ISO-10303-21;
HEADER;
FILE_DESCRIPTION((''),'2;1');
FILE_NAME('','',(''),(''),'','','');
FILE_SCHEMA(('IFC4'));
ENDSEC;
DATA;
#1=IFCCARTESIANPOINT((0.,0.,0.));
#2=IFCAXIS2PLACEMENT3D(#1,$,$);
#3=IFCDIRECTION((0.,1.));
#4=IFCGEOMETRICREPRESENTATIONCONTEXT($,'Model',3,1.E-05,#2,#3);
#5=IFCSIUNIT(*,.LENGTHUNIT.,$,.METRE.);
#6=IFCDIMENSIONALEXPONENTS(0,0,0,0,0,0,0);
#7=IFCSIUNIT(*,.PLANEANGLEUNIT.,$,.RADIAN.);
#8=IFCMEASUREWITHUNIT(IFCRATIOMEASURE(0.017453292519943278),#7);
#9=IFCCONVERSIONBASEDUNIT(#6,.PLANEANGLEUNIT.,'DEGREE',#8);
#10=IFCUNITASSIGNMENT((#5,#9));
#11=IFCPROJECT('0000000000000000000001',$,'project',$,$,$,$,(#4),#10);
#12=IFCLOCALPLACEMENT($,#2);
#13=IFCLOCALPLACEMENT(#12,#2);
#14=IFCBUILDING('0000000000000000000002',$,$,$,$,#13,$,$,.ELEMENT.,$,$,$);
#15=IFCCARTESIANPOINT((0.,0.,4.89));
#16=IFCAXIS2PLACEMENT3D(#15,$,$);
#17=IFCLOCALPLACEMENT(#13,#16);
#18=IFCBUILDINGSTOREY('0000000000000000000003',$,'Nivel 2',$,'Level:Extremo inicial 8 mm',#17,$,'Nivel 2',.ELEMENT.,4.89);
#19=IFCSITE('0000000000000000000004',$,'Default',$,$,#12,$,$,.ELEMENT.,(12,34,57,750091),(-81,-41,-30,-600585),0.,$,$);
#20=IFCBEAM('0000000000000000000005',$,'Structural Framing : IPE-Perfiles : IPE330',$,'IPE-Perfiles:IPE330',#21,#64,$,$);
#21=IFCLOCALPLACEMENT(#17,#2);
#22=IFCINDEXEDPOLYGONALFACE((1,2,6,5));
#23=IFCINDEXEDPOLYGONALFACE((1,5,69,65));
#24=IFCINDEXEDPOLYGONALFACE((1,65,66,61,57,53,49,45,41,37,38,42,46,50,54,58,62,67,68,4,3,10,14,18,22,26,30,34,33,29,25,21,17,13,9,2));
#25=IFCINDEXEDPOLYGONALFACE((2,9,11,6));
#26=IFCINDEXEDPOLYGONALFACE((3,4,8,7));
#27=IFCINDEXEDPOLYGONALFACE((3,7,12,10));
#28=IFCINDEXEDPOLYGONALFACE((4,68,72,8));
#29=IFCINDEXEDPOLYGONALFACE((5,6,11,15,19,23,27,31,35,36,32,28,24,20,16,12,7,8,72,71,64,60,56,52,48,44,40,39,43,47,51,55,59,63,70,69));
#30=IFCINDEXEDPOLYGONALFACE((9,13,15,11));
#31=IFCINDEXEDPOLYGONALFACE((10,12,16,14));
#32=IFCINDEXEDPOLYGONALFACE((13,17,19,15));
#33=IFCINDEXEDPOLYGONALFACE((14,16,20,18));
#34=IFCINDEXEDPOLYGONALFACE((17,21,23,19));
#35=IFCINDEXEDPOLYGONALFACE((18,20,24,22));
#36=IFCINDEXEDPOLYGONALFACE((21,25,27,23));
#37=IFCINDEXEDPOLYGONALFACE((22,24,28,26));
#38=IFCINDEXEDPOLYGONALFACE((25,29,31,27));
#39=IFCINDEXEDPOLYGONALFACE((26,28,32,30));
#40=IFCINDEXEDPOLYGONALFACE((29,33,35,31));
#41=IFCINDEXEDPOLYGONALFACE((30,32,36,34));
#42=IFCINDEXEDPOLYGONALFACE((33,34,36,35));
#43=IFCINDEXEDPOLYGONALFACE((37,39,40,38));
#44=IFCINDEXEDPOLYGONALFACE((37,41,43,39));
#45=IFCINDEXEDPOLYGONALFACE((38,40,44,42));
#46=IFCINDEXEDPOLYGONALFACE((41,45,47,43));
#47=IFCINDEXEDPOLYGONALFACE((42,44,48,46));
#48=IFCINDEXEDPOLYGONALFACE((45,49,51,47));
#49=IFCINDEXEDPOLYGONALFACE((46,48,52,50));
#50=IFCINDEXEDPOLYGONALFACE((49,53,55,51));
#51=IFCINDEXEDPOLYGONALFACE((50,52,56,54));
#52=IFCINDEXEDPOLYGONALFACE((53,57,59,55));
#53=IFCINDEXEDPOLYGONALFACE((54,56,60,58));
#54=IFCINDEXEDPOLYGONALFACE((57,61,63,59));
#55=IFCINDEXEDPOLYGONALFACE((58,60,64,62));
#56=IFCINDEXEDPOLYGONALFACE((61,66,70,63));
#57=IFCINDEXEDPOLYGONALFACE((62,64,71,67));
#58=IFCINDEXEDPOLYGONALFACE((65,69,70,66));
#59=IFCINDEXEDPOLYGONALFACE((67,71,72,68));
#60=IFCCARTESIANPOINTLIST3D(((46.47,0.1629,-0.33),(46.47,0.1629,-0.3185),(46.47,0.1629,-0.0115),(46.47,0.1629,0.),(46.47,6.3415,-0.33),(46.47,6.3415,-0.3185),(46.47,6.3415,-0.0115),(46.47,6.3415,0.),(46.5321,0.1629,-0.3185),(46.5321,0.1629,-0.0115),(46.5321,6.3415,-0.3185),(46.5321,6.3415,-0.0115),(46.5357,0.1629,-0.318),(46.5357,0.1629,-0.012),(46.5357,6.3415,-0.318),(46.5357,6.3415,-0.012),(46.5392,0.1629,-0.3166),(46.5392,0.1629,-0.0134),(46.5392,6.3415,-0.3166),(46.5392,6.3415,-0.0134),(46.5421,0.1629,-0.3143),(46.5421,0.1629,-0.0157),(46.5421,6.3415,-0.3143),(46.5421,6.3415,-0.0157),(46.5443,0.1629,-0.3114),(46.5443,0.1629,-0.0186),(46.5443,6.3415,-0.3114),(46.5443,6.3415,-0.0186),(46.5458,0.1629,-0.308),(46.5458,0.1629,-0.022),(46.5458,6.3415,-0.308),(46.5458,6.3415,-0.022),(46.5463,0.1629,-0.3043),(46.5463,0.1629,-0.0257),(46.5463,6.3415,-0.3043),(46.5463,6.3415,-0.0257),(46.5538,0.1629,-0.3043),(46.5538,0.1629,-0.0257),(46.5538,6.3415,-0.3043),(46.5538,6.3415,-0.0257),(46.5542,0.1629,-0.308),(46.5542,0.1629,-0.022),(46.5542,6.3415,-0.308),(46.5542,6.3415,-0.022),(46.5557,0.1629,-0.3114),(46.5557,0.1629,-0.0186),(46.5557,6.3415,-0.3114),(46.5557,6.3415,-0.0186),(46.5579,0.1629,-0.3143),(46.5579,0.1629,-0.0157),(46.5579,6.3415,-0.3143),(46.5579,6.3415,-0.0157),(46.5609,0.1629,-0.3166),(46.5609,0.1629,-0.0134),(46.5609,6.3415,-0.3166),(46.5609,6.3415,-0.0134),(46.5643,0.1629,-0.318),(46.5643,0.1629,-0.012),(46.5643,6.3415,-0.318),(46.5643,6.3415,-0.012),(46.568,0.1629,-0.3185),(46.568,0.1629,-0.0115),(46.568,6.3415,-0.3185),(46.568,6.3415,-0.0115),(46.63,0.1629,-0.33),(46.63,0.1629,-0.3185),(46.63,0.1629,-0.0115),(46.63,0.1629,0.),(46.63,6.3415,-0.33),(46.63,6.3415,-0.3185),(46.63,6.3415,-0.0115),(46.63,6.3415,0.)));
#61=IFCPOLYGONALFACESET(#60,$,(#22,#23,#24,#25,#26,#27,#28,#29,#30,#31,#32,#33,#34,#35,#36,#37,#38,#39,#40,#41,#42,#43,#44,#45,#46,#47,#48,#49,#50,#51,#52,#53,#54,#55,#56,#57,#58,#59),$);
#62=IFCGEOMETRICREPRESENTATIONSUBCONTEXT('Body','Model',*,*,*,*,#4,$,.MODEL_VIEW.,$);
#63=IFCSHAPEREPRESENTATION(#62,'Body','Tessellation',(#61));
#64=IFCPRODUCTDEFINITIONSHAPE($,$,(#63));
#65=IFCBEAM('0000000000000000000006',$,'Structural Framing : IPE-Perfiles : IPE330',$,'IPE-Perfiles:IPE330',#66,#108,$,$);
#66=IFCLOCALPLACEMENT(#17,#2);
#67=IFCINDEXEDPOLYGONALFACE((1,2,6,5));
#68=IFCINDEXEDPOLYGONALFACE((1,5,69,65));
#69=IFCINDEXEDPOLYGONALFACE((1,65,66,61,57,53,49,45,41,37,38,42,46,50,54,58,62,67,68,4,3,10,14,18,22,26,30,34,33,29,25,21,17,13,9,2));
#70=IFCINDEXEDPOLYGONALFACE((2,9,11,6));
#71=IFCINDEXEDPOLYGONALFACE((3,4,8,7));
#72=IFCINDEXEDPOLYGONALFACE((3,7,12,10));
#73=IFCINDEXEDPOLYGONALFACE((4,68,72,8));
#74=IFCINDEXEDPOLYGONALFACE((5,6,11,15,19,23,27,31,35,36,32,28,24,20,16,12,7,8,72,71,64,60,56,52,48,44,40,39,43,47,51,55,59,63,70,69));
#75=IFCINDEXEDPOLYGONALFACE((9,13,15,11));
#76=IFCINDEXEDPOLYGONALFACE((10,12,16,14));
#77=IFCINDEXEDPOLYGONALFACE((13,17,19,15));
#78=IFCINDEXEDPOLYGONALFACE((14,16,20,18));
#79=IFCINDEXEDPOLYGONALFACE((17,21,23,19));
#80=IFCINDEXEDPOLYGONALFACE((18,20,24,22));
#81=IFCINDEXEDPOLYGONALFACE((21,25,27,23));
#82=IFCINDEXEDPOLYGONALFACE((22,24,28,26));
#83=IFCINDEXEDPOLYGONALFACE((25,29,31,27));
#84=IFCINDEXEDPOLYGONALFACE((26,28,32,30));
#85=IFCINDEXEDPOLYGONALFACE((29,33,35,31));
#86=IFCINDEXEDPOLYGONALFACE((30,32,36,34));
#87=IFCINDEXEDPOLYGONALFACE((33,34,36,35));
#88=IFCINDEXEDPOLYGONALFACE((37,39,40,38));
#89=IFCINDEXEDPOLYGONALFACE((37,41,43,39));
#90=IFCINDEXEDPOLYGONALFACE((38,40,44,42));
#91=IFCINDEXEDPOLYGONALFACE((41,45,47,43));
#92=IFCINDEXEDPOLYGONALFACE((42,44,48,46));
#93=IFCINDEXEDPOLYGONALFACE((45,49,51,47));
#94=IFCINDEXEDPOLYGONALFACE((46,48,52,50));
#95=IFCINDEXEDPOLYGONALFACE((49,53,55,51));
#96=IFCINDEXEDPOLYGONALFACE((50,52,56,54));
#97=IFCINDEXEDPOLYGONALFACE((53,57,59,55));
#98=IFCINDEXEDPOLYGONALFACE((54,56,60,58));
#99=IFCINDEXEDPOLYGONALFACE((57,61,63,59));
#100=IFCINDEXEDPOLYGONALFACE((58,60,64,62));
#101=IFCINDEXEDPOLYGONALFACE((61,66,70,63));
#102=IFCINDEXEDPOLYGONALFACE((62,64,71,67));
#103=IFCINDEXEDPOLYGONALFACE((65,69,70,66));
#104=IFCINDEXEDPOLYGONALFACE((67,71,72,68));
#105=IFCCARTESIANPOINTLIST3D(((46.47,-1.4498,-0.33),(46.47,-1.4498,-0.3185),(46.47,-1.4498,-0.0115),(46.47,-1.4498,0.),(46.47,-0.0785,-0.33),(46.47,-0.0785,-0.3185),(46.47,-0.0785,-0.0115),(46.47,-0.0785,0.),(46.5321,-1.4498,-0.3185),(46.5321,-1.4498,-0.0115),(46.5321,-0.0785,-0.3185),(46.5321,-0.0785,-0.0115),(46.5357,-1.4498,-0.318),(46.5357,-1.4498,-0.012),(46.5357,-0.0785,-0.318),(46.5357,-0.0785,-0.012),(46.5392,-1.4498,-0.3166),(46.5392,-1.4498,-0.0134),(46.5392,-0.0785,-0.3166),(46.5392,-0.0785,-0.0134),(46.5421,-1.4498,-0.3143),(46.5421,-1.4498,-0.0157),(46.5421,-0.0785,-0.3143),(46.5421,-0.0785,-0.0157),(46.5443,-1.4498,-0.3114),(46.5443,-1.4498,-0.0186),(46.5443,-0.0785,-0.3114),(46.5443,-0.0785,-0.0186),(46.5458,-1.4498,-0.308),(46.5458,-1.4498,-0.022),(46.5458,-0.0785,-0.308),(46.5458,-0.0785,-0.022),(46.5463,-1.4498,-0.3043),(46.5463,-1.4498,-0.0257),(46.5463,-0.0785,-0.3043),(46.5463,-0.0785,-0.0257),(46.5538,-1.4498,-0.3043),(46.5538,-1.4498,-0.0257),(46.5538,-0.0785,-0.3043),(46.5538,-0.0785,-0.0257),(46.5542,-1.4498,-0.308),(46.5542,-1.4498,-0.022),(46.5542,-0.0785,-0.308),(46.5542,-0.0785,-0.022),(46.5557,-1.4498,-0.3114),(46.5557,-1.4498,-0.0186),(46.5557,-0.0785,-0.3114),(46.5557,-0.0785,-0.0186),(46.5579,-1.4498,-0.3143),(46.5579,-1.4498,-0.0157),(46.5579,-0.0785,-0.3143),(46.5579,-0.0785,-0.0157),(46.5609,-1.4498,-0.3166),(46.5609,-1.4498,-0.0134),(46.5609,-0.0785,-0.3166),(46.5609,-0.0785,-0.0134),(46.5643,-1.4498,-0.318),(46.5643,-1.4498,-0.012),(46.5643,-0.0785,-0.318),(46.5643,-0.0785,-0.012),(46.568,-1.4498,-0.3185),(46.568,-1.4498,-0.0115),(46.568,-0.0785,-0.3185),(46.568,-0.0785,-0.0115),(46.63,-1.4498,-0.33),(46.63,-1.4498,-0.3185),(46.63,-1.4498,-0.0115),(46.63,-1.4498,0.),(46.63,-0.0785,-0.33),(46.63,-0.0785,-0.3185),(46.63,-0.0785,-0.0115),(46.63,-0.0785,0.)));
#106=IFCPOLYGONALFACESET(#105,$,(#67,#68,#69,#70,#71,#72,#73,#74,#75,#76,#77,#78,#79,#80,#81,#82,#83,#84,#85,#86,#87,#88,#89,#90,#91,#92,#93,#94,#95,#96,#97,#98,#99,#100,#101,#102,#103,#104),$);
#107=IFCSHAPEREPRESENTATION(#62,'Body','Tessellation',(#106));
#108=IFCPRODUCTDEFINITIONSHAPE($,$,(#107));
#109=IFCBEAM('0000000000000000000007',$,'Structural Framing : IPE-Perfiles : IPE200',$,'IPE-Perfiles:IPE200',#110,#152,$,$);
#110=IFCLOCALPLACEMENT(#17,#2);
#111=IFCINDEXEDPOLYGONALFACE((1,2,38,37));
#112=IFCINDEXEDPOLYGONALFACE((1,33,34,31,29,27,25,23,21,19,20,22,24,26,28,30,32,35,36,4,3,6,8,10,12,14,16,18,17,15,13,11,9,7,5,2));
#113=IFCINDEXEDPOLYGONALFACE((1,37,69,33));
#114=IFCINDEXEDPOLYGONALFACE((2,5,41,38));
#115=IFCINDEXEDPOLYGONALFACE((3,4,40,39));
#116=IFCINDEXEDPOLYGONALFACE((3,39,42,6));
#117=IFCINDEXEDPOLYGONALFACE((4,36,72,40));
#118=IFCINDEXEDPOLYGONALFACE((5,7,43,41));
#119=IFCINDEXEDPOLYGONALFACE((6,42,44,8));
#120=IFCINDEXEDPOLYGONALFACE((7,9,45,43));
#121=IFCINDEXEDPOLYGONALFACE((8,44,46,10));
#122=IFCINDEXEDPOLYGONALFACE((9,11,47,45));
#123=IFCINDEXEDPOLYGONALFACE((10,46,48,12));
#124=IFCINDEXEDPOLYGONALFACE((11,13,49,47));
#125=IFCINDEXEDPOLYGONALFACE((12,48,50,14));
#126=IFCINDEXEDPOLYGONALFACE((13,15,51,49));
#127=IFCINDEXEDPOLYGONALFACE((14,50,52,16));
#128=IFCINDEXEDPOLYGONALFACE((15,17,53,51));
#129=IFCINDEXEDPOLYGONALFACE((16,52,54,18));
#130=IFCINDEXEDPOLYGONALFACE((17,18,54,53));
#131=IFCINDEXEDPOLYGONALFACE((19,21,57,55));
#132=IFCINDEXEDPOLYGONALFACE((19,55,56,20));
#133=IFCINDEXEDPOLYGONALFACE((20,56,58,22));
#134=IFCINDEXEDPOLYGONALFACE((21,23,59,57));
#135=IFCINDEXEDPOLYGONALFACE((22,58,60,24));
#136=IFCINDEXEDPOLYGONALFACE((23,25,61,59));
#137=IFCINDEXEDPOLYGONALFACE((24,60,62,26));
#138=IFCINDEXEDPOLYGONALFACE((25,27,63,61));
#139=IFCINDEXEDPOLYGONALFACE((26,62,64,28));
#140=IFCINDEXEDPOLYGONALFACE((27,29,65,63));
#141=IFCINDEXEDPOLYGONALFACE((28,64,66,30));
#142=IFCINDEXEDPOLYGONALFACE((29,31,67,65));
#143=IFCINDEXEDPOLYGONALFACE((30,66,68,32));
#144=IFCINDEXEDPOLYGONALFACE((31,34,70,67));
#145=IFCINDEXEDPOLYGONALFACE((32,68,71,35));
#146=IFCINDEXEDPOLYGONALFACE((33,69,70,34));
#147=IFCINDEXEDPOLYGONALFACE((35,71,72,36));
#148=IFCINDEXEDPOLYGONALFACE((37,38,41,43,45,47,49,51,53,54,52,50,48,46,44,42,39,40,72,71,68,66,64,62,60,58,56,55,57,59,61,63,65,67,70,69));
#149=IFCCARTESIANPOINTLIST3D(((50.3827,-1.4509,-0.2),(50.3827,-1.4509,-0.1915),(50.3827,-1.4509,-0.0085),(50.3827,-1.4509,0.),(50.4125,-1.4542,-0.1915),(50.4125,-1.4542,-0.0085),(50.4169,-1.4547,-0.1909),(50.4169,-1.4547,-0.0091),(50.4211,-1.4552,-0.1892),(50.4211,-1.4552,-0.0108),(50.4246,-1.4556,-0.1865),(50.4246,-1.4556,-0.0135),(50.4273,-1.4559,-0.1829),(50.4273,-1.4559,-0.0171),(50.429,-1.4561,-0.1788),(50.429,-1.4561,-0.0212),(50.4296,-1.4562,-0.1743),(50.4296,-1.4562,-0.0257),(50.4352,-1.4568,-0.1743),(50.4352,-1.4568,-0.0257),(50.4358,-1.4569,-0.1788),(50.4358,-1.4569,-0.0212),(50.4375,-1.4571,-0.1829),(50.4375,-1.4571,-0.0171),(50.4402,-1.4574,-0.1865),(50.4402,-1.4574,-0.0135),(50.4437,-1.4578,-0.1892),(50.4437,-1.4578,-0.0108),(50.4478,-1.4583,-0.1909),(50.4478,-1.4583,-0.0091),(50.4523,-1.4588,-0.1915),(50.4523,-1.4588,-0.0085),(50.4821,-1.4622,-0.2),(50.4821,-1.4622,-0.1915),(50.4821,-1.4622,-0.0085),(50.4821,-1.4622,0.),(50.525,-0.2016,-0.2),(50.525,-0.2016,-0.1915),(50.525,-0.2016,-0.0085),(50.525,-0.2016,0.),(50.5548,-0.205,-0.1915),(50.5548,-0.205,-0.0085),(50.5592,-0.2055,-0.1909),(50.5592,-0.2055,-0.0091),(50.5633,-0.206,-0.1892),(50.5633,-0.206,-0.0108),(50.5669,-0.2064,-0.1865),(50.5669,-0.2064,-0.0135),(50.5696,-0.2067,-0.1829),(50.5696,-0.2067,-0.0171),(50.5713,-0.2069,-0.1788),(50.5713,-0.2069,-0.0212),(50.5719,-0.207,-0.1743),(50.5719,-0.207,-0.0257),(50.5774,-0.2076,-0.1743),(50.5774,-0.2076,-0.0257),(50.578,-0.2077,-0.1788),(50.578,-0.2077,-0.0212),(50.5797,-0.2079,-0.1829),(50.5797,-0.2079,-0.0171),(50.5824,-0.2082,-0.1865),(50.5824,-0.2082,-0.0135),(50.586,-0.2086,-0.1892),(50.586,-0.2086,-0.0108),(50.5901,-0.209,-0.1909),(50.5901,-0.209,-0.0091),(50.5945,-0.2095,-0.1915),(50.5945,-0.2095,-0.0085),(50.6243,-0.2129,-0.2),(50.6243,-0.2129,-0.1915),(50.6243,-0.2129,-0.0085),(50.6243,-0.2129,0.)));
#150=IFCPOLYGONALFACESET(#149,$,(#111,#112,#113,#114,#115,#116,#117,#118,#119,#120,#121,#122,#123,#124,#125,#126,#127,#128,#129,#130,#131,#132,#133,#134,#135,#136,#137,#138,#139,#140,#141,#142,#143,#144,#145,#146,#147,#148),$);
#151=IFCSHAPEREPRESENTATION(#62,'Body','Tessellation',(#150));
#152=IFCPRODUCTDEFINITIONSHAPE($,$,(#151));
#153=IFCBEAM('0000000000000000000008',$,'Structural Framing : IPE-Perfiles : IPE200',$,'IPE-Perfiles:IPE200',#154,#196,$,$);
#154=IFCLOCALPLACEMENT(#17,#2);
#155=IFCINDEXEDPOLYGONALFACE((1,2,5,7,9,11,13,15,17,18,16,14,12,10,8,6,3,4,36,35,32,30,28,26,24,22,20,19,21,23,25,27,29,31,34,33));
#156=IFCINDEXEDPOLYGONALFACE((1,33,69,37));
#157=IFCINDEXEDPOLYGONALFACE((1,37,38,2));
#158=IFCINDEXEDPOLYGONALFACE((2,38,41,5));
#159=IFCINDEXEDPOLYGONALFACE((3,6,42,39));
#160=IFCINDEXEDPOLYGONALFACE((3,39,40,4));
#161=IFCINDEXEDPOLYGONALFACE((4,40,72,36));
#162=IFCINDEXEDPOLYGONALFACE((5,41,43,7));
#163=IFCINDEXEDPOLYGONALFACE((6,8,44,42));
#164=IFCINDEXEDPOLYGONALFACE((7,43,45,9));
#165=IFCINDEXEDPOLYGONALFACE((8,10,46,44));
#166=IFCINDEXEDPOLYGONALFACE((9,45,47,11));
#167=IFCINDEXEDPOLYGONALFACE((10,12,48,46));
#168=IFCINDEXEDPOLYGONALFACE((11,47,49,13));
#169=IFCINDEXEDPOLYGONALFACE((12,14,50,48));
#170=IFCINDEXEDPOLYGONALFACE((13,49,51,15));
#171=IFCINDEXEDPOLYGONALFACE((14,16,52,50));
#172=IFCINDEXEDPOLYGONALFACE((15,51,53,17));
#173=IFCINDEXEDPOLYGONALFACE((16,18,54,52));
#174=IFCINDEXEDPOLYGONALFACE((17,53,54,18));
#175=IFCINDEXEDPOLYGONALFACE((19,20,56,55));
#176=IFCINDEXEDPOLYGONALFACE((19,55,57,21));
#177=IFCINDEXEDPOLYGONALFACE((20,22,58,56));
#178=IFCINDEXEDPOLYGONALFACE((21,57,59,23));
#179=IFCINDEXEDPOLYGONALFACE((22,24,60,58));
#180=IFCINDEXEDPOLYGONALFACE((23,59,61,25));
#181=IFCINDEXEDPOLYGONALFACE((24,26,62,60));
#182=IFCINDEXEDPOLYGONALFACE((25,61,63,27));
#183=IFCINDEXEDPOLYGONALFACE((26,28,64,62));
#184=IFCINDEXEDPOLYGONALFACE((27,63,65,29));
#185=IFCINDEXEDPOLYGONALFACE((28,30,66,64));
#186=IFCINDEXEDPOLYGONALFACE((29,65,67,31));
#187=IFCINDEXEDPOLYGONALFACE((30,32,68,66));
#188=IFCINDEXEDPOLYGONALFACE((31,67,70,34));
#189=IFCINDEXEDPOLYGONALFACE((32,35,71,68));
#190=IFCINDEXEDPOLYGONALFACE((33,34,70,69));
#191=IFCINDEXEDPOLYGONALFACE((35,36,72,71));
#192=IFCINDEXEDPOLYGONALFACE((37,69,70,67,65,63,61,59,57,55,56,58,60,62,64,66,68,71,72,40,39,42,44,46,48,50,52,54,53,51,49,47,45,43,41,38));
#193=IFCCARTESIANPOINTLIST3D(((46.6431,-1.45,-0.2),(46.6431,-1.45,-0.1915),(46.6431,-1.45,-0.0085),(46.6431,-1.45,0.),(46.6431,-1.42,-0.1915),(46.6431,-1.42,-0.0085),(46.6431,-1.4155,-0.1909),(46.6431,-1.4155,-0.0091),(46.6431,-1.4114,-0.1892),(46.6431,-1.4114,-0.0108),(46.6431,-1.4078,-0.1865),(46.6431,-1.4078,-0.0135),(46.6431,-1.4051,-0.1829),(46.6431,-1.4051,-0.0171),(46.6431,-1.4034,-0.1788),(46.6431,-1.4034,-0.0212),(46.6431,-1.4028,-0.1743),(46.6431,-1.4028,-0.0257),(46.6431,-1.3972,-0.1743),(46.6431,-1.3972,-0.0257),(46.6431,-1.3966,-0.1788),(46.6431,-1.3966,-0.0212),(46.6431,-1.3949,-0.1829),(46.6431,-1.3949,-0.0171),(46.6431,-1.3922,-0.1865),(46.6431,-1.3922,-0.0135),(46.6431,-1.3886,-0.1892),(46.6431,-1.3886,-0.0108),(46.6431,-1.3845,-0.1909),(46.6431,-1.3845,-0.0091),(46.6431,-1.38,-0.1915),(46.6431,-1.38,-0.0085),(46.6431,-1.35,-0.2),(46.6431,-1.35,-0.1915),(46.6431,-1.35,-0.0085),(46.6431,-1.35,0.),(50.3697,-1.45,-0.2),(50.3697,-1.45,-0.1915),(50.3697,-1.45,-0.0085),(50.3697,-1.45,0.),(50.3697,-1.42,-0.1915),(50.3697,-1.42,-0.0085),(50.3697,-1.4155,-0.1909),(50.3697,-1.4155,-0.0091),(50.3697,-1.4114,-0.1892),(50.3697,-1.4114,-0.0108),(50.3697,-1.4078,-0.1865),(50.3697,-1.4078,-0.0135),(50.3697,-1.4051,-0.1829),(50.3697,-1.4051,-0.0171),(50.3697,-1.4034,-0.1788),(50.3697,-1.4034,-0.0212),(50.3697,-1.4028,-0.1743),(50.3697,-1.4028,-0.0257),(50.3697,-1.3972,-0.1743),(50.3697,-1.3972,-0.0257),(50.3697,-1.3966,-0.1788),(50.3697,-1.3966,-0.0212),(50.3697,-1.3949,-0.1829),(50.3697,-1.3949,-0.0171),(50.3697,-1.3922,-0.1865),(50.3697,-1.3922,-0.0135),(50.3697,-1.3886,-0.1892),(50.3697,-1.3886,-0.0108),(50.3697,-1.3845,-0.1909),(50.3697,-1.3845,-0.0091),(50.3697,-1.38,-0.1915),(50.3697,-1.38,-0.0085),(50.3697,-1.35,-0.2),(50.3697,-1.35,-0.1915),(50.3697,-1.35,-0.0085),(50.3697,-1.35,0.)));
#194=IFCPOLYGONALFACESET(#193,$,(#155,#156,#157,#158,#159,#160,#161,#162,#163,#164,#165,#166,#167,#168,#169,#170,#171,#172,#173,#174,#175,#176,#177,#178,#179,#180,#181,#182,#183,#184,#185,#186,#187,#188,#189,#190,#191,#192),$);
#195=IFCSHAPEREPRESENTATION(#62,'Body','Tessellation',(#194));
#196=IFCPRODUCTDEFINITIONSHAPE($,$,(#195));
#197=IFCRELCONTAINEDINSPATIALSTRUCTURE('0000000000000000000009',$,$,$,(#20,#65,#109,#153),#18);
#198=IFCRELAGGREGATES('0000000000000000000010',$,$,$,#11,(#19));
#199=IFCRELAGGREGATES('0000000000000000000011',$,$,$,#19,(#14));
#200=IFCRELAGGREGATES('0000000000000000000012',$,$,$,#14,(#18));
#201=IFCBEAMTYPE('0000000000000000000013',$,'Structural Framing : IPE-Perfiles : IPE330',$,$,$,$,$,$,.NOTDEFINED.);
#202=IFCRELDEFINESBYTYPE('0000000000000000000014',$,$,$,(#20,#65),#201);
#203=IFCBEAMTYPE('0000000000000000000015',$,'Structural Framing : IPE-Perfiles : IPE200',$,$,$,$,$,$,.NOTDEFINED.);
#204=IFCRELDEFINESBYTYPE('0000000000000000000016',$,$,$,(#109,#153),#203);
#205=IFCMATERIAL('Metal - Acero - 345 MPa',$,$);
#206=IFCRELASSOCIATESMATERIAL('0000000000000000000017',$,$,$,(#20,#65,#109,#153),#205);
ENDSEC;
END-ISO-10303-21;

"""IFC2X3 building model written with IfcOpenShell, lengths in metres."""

from ifc_helpers import new_model, entity, si_unit, converted_unit, direction, frame, frame_2d, origin, place, context, subcontext, project, spatial, i_section, extrude, material, type_object, element, save


model = new_model("IFC2X3")

# Units and contexts
model_context = context("Model", 3, precision=1e-05, world=origin(), true_north=direction((0.0, 1.0)))
body_context = subcontext(model_context, "Body", "Model", "MODEL_VIEW")
ifc_project = project(units=[si_unit("LENGTHUNIT", "METRE"), converted_unit("PLANEANGLEUNIT", "DEGREE", entity("IfcRatioMeasure", 0.017453292519943278), si_unit("PLANEANGLEUNIT", "RADIAN"), dimensions=[0, 0, 0, 0, 0, 0, 0])], contexts=[model_context])

# Site, building, storey
site_placement = place(None, origin())
site = spatial("IfcSite", under=ifc_project, at=site_placement, Name="Default", CompositionType="ELEMENT", RefLatitude=(12, 34, 57, 750091), RefLongitude=(-81, -41, -30, -600585), RefElevation=0.0)
building_placement = place(site_placement, origin())
building = spatial("IfcBuilding", under=site, at=building_placement, CompositionType="ELEMENT")
storey_placement = place(building_placement, frame((0.0, 0.0, 4.89)))
storey = spatial("IfcBuildingStorey", under=building, at=storey_placement, Name="Nivel 2", ObjectType="Level:Extremo inicial 8 mm", LongName="Nivel 2", CompositionType="ELEMENT", Elevation=4.89)

# Shared definitions
ifc_material_1 = material(Name="Metal - Acero - 345 MPa")

# Beams
beam_type_1 = type_object("IfcBeamType", Name="Structural Framing : IPE-Perfiles : IPE330", PredefinedType="NOTDEFINED")
beam_1_placement = place(storey_placement, frame((46.55, 6.355, 0.0), z_axis=(0.0, 0.0, 1.0), x_axis=(0.0, -1.0, 0.0)))
element("IfcBeam", 1, at=beam_1_placement, inside=storey, type_object=beam_type_1, material=ifc_material_1, Name="Structural Framing : IPE-Perfiles : IPE330", ObjectType="IPE-Perfiles:IPE330", context=body_context, shape_type="SweptSolid", body=[
    extrude(i_section(OverallWidth=0.16, OverallDepth=0.33, WebThickness=0.0075, FlangeThickness=0.0115, FilletRadius=0.0142, at=frame_2d((0.0, 0.0), x_axis=(0.0, 1.0))), frame((0.0134, 0.0, -0.165), z_axis=(1.0, 0.0, 0.0), x_axis=(0.0, 0.0, -1.0)), (0.0, 0.0, 1.0), 6.1786),
])
beam_2_placement = place(storey_placement, frame((46.55, 0.0795, 0.0), z_axis=(0.0, 0.0, 1.0), x_axis=(0.0, -1.0, 0.0)))
element("IfcBeam", 2, at=beam_2_placement, inside=storey, type_object=beam_type_1, material=ifc_material_1, Name="Structural Framing : IPE-Perfiles : IPE330", ObjectType="IPE-Perfiles:IPE330", context=body_context, shape_type="SweptSolid", body=[
    extrude(i_section(OverallWidth=0.16, OverallDepth=0.33, WebThickness=0.0075, FlangeThickness=0.0115, FilletRadius=0.0142, at=frame_2d((0.0, 0.0), x_axis=(0.0, 1.0))), frame((0.1579, 0.0, -0.165), z_axis=(1.0, 0.0, 0.0), x_axis=(0.0, 0.0, -1.0)), (0.0, 0.0, 1.0), 1.3713),
])
beam_type_2 = type_object("IfcBeamType", Name="Structural Framing : IPE-Perfiles : IPE200", PredefinedType="NOTDEFINED")
beam_3_placement = place(storey_placement, frame((50.4388, -1.4, 0.0), z_axis=(0.0, 0.0, 1.0), x_axis=(0.113151, 0.993578, 0.0)))
element("IfcBeam", 3, at=beam_3_placement, inside=storey, type_object=beam_type_2, material=ifc_material_1, Name="Structural Framing : IPE-Perfiles : IPE200", ObjectType="IPE-Perfiles:IPE200", context=body_context, shape_type="SweptSolid", body=[
    extrude(i_section(OverallWidth=0.1, OverallDepth=0.2, WebThickness=0.0056, FlangeThickness=0.0085, FilletRadius=0.0172, at=frame_2d((0.0, 0.0), x_axis=(0.0, 1.0))), frame((-0.0569, 0.0, -0.1), z_axis=(1.0, 0.0, 0.0), x_axis=(0.0, 0.0, -1.0)), (0.0, 0.0, 1.0), 1.2573),
])
beam_4_placement = place(storey_placement, frame((46.55, -1.4, 0.0)))
element("IfcBeam", 4, at=beam_4_placement, inside=storey, type_object=beam_type_2, material=ifc_material_1, Name="Structural Framing : IPE-Perfiles : IPE200", ObjectType="IPE-Perfiles:IPE200", context=body_context, shape_type="SweptSolid", body=[
    extrude(i_section(OverallWidth=0.1, OverallDepth=0.2, WebThickness=0.0056, FlangeThickness=0.0085, FilletRadius=0.0172, at=frame_2d((0.0, 0.0), x_axis=(0.0, 1.0))), frame((0.0931, 0.0, -0.1), z_axis=(1.0, 0.0, 0.0), x_axis=(0.0, 0.0, -1.0)), (0.0, 0.0, 1.0), 3.7266),
])

save(model, "model.ifc")
